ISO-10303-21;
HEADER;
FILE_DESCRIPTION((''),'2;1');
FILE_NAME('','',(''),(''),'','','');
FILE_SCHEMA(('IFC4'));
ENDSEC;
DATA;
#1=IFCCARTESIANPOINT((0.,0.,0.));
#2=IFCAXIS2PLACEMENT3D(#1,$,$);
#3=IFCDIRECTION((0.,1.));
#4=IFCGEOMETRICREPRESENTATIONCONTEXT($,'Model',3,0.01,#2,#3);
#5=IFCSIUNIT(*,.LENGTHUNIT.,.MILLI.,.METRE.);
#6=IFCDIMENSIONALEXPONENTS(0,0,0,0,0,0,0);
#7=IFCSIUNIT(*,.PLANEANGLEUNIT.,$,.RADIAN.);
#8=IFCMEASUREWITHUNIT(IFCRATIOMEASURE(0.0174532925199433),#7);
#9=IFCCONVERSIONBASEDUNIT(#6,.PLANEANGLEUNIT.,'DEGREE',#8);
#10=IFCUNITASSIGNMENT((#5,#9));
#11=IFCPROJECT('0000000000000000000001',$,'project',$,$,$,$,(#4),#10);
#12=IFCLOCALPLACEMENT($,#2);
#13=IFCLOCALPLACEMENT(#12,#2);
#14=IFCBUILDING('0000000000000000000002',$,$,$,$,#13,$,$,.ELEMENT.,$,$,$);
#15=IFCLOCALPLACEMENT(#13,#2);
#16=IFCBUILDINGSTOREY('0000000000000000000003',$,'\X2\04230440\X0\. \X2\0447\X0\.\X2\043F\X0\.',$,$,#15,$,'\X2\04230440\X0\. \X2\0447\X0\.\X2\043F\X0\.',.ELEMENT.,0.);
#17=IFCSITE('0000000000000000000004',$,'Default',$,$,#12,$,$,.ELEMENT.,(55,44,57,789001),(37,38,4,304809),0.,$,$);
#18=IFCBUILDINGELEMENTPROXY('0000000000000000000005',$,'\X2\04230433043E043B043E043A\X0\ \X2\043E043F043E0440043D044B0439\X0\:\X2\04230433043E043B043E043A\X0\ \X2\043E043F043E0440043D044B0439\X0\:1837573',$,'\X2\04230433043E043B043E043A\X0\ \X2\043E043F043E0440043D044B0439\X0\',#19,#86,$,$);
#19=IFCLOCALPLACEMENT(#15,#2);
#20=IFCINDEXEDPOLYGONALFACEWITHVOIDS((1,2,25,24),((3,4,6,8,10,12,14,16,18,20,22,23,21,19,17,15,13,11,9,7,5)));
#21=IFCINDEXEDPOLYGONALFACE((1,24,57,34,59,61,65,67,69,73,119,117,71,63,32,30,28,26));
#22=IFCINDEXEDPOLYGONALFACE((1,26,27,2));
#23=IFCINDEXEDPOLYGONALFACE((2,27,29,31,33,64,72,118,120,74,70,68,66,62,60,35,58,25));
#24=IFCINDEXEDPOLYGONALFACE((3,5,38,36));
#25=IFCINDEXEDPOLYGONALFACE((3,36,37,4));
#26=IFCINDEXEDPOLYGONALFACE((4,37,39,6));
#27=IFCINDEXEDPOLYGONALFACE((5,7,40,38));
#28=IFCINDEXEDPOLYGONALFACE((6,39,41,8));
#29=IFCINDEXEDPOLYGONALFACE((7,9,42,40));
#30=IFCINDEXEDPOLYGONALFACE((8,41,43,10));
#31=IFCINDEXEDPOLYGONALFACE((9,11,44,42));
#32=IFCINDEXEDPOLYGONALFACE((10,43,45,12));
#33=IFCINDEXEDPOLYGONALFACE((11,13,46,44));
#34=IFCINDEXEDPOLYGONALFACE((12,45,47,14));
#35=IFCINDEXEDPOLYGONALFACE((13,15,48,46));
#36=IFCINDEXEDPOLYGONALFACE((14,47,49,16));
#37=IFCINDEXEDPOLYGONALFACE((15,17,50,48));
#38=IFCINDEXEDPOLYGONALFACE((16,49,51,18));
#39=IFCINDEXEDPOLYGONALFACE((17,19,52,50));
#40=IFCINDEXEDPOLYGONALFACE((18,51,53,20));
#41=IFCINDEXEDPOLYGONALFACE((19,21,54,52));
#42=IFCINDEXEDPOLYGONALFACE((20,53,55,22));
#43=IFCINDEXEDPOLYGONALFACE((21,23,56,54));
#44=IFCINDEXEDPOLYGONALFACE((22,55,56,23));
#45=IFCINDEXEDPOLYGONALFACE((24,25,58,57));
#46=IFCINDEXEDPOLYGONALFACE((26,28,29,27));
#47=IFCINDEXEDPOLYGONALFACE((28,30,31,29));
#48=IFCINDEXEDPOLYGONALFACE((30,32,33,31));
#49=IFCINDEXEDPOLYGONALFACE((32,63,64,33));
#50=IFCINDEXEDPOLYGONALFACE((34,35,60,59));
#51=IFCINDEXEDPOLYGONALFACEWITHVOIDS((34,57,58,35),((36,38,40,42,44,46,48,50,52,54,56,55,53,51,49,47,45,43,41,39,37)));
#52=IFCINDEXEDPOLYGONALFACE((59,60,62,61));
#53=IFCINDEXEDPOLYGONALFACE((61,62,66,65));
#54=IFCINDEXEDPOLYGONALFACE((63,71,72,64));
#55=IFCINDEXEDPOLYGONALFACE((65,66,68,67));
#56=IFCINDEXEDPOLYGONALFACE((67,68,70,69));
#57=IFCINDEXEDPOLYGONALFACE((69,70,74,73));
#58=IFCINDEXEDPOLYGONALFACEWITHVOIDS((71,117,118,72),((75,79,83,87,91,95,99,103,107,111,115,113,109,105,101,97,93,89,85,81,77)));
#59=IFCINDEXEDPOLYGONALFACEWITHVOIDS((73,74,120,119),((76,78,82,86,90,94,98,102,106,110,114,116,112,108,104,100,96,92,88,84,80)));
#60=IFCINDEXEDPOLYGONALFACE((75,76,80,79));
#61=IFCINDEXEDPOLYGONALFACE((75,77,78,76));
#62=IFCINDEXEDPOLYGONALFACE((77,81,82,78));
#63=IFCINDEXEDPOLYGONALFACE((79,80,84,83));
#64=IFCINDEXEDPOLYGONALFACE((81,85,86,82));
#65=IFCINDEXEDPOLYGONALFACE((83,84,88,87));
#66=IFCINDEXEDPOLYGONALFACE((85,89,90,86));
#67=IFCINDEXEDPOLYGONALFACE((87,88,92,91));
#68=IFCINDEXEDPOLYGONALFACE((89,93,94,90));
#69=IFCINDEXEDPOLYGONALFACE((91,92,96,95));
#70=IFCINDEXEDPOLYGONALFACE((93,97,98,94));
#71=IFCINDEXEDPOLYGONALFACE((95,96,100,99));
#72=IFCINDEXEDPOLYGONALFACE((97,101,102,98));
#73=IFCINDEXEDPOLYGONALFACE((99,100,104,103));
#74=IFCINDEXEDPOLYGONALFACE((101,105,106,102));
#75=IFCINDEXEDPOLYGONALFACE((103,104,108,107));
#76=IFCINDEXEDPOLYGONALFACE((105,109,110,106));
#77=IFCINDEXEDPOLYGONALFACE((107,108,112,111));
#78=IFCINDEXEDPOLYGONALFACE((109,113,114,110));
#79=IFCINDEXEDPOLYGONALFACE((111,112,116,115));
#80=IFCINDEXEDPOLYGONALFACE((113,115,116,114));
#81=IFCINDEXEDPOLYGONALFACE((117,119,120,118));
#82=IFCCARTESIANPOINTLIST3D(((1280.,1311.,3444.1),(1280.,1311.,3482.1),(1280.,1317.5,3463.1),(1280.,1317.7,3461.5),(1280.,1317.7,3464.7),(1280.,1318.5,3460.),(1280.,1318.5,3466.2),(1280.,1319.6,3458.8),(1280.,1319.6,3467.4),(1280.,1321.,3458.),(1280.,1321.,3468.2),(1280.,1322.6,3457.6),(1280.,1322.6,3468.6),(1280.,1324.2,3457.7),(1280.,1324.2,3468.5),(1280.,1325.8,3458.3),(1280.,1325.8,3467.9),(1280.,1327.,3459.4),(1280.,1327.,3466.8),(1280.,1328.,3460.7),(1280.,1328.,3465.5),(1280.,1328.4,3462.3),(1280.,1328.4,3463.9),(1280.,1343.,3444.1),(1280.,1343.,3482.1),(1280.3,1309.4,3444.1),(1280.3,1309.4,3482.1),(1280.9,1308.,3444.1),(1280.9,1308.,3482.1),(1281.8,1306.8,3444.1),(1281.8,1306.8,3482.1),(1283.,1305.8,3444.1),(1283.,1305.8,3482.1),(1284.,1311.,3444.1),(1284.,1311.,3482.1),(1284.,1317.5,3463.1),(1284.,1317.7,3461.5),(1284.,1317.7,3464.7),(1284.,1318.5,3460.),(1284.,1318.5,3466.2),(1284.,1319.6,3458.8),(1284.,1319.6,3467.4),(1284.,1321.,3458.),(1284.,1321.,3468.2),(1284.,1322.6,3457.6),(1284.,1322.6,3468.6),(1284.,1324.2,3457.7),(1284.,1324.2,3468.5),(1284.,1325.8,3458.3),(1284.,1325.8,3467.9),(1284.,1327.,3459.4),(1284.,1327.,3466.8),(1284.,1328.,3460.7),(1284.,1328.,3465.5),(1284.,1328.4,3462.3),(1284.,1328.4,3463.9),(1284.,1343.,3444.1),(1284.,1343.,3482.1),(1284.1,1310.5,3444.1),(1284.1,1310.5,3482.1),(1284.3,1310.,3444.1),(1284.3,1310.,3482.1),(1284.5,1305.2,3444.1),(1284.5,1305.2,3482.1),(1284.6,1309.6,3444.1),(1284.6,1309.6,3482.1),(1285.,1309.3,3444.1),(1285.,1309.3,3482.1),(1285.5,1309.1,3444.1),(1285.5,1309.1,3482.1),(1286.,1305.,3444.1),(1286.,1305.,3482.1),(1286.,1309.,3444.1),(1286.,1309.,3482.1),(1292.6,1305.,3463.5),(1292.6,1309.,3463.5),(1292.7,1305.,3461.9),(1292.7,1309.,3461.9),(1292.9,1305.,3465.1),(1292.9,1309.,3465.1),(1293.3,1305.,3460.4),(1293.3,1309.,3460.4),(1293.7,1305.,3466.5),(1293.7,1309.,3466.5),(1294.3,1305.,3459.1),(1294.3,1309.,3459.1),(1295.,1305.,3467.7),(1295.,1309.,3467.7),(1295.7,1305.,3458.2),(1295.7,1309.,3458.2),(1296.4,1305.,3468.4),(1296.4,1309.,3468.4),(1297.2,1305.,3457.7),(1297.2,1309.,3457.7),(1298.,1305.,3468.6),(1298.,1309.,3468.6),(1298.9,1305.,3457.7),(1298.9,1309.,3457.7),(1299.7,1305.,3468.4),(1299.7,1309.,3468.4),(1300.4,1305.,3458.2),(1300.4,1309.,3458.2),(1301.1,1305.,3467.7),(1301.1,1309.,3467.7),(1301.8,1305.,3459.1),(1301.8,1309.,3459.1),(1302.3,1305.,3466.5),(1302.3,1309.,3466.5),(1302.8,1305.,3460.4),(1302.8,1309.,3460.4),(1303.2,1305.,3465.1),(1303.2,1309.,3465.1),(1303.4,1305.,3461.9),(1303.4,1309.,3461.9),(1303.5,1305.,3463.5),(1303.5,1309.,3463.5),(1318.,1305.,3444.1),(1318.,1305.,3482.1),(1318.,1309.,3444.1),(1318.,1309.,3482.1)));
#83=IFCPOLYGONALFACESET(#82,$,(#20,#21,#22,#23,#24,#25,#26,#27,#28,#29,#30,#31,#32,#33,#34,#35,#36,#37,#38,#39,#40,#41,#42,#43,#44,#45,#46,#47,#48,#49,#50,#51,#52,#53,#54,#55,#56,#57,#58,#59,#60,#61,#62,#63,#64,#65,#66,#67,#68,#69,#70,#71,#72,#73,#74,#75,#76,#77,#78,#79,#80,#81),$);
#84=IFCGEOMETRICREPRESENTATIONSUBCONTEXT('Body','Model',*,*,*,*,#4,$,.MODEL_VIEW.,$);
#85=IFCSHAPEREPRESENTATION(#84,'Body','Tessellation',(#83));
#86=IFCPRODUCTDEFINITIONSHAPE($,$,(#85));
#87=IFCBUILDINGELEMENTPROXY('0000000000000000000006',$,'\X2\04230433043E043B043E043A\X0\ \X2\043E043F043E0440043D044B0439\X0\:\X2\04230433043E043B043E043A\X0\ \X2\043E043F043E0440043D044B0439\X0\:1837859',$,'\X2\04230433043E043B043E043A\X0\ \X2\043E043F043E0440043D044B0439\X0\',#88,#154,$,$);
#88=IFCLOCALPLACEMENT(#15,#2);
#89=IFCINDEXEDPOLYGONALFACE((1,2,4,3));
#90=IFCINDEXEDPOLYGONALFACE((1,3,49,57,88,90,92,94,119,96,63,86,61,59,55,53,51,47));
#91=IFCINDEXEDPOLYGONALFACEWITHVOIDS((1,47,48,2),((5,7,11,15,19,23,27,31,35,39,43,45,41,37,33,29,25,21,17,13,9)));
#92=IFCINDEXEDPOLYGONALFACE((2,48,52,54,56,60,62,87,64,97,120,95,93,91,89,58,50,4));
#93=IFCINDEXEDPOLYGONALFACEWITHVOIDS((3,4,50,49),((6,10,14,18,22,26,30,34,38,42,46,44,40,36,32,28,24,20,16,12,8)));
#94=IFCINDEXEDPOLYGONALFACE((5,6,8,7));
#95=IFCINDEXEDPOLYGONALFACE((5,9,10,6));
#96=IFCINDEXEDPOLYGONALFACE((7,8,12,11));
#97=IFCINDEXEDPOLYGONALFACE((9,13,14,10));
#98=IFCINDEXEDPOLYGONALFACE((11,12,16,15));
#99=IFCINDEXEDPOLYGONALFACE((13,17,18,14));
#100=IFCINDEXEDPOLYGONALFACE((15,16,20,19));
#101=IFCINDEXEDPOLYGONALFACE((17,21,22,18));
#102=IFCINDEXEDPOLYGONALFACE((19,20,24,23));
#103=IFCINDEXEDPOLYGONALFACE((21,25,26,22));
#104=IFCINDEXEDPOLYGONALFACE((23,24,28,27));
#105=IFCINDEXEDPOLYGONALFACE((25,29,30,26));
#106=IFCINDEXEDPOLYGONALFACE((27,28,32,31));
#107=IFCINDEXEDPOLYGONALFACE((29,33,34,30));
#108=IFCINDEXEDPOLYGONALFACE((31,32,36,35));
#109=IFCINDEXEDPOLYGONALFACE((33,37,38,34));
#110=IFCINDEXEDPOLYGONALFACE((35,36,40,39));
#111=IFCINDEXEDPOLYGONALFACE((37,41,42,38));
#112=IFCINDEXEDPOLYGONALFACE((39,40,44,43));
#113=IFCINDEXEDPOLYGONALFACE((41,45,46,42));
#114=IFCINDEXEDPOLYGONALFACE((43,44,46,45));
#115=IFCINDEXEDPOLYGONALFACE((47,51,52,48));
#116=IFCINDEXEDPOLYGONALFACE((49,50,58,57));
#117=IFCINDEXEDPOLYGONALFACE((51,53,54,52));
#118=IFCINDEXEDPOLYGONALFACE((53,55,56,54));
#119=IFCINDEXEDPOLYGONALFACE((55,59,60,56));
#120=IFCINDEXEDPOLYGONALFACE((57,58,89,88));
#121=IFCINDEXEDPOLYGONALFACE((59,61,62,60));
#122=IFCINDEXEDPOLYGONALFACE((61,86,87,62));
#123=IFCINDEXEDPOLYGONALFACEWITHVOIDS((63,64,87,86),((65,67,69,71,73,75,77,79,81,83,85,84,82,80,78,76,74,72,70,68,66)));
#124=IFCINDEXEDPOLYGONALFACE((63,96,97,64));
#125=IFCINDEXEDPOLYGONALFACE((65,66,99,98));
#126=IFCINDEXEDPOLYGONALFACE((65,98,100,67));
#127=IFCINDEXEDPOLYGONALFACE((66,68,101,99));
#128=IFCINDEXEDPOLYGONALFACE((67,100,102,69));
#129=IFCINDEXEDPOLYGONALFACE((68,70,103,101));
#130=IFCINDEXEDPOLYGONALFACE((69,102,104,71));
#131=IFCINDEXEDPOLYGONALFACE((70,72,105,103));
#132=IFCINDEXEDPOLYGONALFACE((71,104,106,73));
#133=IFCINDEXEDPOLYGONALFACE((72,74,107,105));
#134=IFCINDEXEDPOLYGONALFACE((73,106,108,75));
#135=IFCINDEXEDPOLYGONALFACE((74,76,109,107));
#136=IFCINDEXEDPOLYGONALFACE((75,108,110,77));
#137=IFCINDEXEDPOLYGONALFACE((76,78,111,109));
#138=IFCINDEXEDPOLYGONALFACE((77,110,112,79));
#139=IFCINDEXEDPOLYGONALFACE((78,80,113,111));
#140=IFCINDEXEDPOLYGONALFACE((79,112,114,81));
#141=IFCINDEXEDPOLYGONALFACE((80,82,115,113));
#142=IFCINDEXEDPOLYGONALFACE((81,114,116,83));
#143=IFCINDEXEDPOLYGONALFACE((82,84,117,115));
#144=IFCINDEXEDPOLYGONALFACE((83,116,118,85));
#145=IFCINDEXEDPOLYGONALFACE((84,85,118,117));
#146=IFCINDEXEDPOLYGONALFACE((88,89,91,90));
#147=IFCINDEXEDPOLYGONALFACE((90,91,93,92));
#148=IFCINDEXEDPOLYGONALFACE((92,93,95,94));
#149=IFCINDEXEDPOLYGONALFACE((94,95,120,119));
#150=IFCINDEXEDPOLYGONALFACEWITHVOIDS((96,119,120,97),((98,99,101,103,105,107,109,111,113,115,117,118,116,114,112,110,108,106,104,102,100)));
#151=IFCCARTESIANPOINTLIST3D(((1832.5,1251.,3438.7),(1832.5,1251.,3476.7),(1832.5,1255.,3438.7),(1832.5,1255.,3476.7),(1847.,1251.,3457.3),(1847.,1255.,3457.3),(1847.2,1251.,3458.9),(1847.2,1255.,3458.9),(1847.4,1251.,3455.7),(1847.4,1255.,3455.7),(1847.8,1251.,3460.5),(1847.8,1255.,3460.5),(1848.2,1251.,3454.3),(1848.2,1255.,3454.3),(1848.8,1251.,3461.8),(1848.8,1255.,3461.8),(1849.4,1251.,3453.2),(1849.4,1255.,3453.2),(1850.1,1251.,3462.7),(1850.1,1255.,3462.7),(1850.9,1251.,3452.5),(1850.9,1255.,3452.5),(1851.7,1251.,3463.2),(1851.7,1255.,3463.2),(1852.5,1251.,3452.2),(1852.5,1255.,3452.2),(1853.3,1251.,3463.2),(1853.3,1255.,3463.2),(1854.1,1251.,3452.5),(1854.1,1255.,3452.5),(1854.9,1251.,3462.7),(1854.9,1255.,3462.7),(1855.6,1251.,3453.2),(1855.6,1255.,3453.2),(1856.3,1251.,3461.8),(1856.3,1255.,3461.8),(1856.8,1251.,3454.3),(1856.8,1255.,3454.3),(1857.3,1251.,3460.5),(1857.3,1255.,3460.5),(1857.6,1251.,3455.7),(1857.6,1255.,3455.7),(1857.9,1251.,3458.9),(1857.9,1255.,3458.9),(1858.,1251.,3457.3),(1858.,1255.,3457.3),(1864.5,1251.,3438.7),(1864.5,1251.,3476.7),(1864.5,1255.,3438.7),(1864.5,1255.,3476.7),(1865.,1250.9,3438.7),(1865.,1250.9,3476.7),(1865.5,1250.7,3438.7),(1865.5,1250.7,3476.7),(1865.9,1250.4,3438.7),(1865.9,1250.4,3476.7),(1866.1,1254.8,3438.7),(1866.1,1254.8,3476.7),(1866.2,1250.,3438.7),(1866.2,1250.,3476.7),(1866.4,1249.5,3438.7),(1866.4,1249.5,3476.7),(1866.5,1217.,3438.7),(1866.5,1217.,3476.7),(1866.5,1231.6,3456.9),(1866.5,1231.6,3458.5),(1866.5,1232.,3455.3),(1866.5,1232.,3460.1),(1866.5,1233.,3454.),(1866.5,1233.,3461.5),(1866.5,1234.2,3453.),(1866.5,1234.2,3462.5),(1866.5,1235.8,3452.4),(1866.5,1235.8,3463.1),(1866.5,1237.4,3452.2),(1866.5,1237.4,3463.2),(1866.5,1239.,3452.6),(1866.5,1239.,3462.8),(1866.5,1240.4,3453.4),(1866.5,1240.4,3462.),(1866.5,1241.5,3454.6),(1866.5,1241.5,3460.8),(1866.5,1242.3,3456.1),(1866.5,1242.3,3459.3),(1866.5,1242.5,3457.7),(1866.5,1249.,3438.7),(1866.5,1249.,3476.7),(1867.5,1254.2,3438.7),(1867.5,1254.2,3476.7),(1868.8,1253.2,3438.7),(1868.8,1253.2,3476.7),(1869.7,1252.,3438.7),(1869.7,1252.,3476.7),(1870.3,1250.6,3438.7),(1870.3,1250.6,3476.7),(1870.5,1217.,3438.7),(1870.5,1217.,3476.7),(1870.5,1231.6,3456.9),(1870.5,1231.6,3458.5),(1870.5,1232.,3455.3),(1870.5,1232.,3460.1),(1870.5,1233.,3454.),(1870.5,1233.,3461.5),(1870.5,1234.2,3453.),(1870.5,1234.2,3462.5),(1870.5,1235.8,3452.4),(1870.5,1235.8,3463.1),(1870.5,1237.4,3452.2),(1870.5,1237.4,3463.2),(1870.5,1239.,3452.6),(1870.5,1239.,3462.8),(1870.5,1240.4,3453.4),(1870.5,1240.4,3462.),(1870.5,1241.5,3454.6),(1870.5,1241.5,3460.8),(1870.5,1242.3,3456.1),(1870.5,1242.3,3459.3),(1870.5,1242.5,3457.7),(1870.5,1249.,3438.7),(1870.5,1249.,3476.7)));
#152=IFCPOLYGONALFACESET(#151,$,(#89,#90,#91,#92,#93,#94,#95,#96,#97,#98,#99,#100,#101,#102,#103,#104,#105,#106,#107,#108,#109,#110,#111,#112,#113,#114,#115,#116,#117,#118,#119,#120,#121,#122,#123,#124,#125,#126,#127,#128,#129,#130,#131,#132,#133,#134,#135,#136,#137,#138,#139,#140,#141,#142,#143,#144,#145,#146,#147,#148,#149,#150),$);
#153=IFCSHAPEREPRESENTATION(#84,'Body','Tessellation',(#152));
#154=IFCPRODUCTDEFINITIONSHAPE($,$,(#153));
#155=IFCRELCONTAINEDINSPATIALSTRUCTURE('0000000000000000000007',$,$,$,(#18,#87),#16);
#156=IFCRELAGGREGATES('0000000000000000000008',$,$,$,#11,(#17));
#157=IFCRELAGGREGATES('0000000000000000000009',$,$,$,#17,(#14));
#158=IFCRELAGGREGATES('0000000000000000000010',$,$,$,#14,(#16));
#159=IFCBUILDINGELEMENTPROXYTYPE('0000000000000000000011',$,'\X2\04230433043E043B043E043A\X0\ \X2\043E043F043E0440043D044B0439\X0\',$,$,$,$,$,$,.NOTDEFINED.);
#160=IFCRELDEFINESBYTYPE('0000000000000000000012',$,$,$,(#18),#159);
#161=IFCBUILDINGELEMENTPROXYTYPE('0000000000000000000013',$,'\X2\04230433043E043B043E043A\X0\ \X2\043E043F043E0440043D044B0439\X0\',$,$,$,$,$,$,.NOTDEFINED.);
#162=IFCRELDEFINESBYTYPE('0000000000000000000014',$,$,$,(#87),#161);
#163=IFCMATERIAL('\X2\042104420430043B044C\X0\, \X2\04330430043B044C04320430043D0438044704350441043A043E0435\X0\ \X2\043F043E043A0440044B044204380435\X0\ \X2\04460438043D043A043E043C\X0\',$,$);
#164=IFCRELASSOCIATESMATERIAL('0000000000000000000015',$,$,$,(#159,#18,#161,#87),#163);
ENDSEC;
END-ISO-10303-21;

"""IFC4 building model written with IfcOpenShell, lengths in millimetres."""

from ifc_helpers import new_model, entity, si_unit, converted_unit, direction, frame, frame_2d, origin, place, context, subcontext, project, spatial, polyline, circle_curve, parameter, trimmed, segment, composite_curve, circle, outline, extrude, source, transform, mapped, material, type_object, type_shapes, element, save


model = new_model("IFC4")

# Units and contexts
model_context = context("Model", 3, precision=0.01, world=origin(), true_north=direction((0.0, 1.0)))
body_context = subcontext(model_context, "Body", "Model", "MODEL_VIEW")
ifc_project = project(units=[si_unit("LENGTHUNIT", "METRE", prefix="MILLI"), converted_unit("PLANEANGLEUNIT", "DEGREE", entity("IfcRatioMeasure", 0.0174532925199433), si_unit("PLANEANGLEUNIT", "RADIAN"), dimensions=[0, 0, 0, 0, 0, 0, 0])], contexts=[model_context])

# Site, building, storey
site_placement = place(None, origin())
site = spatial("IfcSite", under=ifc_project, at=site_placement, Name="Default", CompositionType="ELEMENT", RefLatitude=(55, 44, 57, 789001), RefLongitude=(37, 38, 4, 304809), RefElevation=0.0)
building_placement = place(site_placement, origin())
building = spatial("IfcBuilding", under=site, at=building_placement, CompositionType="ELEMENT")
storey_placement = place(building_placement, origin())
storey = spatial("IfcBuildingStorey", under=building, at=storey_placement, Name="Ур. ч.п.", LongName="Ур. ч.п.", CompositionType="ELEMENT", Elevation=0.0)

# Building element proxies, openings
ifc_material_1 = material(Name="Сталь, гальваническое покрытие цинком")
building_element_proxy_type_1 = type_object("IfcBuildingElementProxyType", Name="Уголок опорный", material=ifc_material_1)
shared_shape_1 = source(origin(), body_context, "Body", "SweptSolid", [
    extrude(outline(composite_curve([segment(polyline([(-6.0, -12.0), (26.0, -12.0)]), True, "CONTINUOUS"), segment(polyline([(26.0, -12.0), (26.0, -8.0)]), True, "CONTINUOUS"), segment(polyline([(26.0, -8.0), (-6.0, -8.0)]), True, "CONTINUOUS"), segment(trimmed(circle_curve(frame_2d((-6.0, -6.0), x_axis=(0.0, -1.0)), 2.0), [parameter(270.0)], [parameter(0.0)], True, "PARAMETER"), False, "CONTINUOUS"), segment(polyline([(-8.0, -6.0), (-8.0, 26.0)]), True, "CONTINUOUS"), segment(polyline([(-8.0, 26.0), (-12.0, 26.0)]), True, "CONTINUOUS"), segment(polyline([(-12.0, 26.0), (-12.0, -6.0)]), True, "CONTINUOUS"), segment(trimmed(circle_curve(frame_2d((-6.0, -6.0), x_axis=(0.0, -1.0)), 6.0), [parameter(270.0)], [parameter(360.0)], True, "PARAMETER"), True, "CONTINUOUS")], self_intersect=False)), frame((12.0, -19.0, 12.0), z_axis=(0.0, 1.0, 0.0), x_axis=(0.0, 0.0, 1.0)), (0.0, 0.0, 1.0), 38.0),
])
type_shapes(building_element_proxy_type_1, [shared_shape_1])
proxy_1_placement = place(storey_placement, frame((1280.0, 1305.0, 3463.1), z_axis=(0.0, 1.0, 0.0), x_axis=(1.0, 0.0, 0.0)))
proxy_1 = element("IfcBuildingElementProxy", 1, at=proxy_1_placement, inside=storey, type_object=building_element_proxy_type_1, material=ifc_material_1, Name="Уголок опорный:Уголок опорный:1837573", ObjectType="Уголок опорный", context=body_context, shape_type="MappedRepresentation", body=[
    mapped(shared_shape_1, transform((0.0, 0.0, 0.0), scale=1.0)),
])
opening_1_placement = place(storey_placement, frame((1280.0, 1305.0, 3463.1), z_axis=(0.0, 0.0, -1.0), x_axis=(1.0, 0.0, 0.0)))
element("IfcOpeningElement", 2, at=opening_1_placement, cuts=proxy_1, ObjectType="Opening", PredefinedType="OPENING", context=body_context, shape_type="SweptSolid", body=[
    extrude(circle(Radius=5.5, at=frame_2d((0.0, 0.0), x_axis=(1.0, 0.0))), frame((4.0, -18.0, 0.0), z_axis=(-1.0, 0.0, 0.0), x_axis=(0.0, 1.0, 0.0)), (0.0, 0.0, 1.0), 4.0),
])
opening_2_placement = place(storey_placement, frame((1280.0, 1305.0, 3463.1), z_axis=(0.0, 0.0, -1.0), x_axis=(1.0, 0.0, 0.0)))
element("IfcOpeningElement", 3, at=opening_2_placement, cuts=proxy_1, ObjectType="Opening", PredefinedType="OPENING", context=body_context, shape_type="SweptSolid", body=[
    extrude(circle(Radius=5.5, at=frame_2d((0.0, 0.0), x_axis=(1.0, 0.0))), frame((18.0, 0.0, 0.0), z_axis=(0.0, -1.0, 0.0), x_axis=(0.0, 0.0, -1.0)), (0.0, 0.0, 1.0), 4.0),
])
building_element_proxy_type_2 = type_object("IfcBuildingElementProxyType", Name="Уголок опорный", material=ifc_material_1)
shared_shape_2 = source(origin(), body_context, "Body", "SweptSolid", [
    extrude(outline(composite_curve([segment(polyline([(-6.0, -12.0), (26.0, -12.0)]), True, "CONTINUOUS"), segment(polyline([(26.0, -12.0), (26.0, -8.0)]), True, "CONTINUOUS"), segment(polyline([(26.0, -8.0), (-6.0, -8.0)]), True, "CONTINUOUS"), segment(trimmed(circle_curve(frame_2d((-6.0, -6.0), x_axis=(0.0, -1.0)), 2.0), [parameter(270.0)], [parameter(0.0)], True, "PARAMETER"), False, "CONTINUOUS"), segment(polyline([(-8.0, -6.0), (-8.0, 26.0)]), True, "CONTINUOUS"), segment(polyline([(-8.0, 26.0), (-12.0, 26.0)]), True, "CONTINUOUS"), segment(polyline([(-12.0, 26.0), (-12.0, -6.0)]), True, "CONTINUOUS"), segment(trimmed(circle_curve(frame_2d((-6.0, -6.0), x_axis=(0.0, -1.0)), 6.0), [parameter(270.0)], [parameter(360.0)], True, "PARAMETER"), True, "CONTINUOUS")], self_intersect=False)), frame((12.0, -19.0, 12.0), z_axis=(0.0, 1.0, 0.0), x_axis=(0.0, 0.0, 1.0)), (0.0, 0.0, 1.0), 38.0),
])
type_shapes(building_element_proxy_type_2, [shared_shape_2])
proxy_2_placement = place(storey_placement, frame((1870.5, 1255.0, 3457.7), z_axis=(0.0, -1.0, 0.0), x_axis=(-1.0, 0.0, 0.0)))
proxy_2 = element("IfcBuildingElementProxy", 4, at=proxy_2_placement, inside=storey, type_object=building_element_proxy_type_2, material=ifc_material_1, Name="Уголок опорный:Уголок опорный:1837859", ObjectType="Уголок опорный", context=body_context, shape_type="MappedRepresentation", body=[
    mapped(shared_shape_2, transform((0.0, 0.0, 0.0), scale=1.0)),
])
opening_3_placement = place(storey_placement, frame((1870.5, 1255.0, 3457.7)))
element("IfcOpeningElement", 5, at=opening_3_placement, cuts=proxy_2, ObjectType="Opening", PredefinedType="OPENING", context=body_context, shape_type="SweptSolid", body=[
    extrude(circle(Radius=5.5, at=frame_2d((0.0, 0.0), x_axis=(1.0, 0.0))), frame((0.0, -18.0, 0.0), z_axis=(-1.0, 0.0, 0.0), x_axis=(0.0, 1.0, 0.0)), (0.0, 0.0, 1.0), 4.0),
])
opening_4_placement = place(storey_placement, frame((1870.5, 1255.0, 3457.7)))
element("IfcOpeningElement", 6, at=opening_4_placement, cuts=proxy_2, ObjectType="Opening", PredefinedType="OPENING", context=body_context, shape_type="SweptSolid", body=[
    extrude(circle(Radius=5.5, at=frame_2d((0.0, 0.0), x_axis=(1.0, 0.0))), frame((-18.0, 0.0, 0.0), z_axis=(0.0, -1.0, 0.0), x_axis=(0.0, 0.0, -1.0)), (0.0, 0.0, 1.0), 4.0),
])

save(model, "model.ifc")
